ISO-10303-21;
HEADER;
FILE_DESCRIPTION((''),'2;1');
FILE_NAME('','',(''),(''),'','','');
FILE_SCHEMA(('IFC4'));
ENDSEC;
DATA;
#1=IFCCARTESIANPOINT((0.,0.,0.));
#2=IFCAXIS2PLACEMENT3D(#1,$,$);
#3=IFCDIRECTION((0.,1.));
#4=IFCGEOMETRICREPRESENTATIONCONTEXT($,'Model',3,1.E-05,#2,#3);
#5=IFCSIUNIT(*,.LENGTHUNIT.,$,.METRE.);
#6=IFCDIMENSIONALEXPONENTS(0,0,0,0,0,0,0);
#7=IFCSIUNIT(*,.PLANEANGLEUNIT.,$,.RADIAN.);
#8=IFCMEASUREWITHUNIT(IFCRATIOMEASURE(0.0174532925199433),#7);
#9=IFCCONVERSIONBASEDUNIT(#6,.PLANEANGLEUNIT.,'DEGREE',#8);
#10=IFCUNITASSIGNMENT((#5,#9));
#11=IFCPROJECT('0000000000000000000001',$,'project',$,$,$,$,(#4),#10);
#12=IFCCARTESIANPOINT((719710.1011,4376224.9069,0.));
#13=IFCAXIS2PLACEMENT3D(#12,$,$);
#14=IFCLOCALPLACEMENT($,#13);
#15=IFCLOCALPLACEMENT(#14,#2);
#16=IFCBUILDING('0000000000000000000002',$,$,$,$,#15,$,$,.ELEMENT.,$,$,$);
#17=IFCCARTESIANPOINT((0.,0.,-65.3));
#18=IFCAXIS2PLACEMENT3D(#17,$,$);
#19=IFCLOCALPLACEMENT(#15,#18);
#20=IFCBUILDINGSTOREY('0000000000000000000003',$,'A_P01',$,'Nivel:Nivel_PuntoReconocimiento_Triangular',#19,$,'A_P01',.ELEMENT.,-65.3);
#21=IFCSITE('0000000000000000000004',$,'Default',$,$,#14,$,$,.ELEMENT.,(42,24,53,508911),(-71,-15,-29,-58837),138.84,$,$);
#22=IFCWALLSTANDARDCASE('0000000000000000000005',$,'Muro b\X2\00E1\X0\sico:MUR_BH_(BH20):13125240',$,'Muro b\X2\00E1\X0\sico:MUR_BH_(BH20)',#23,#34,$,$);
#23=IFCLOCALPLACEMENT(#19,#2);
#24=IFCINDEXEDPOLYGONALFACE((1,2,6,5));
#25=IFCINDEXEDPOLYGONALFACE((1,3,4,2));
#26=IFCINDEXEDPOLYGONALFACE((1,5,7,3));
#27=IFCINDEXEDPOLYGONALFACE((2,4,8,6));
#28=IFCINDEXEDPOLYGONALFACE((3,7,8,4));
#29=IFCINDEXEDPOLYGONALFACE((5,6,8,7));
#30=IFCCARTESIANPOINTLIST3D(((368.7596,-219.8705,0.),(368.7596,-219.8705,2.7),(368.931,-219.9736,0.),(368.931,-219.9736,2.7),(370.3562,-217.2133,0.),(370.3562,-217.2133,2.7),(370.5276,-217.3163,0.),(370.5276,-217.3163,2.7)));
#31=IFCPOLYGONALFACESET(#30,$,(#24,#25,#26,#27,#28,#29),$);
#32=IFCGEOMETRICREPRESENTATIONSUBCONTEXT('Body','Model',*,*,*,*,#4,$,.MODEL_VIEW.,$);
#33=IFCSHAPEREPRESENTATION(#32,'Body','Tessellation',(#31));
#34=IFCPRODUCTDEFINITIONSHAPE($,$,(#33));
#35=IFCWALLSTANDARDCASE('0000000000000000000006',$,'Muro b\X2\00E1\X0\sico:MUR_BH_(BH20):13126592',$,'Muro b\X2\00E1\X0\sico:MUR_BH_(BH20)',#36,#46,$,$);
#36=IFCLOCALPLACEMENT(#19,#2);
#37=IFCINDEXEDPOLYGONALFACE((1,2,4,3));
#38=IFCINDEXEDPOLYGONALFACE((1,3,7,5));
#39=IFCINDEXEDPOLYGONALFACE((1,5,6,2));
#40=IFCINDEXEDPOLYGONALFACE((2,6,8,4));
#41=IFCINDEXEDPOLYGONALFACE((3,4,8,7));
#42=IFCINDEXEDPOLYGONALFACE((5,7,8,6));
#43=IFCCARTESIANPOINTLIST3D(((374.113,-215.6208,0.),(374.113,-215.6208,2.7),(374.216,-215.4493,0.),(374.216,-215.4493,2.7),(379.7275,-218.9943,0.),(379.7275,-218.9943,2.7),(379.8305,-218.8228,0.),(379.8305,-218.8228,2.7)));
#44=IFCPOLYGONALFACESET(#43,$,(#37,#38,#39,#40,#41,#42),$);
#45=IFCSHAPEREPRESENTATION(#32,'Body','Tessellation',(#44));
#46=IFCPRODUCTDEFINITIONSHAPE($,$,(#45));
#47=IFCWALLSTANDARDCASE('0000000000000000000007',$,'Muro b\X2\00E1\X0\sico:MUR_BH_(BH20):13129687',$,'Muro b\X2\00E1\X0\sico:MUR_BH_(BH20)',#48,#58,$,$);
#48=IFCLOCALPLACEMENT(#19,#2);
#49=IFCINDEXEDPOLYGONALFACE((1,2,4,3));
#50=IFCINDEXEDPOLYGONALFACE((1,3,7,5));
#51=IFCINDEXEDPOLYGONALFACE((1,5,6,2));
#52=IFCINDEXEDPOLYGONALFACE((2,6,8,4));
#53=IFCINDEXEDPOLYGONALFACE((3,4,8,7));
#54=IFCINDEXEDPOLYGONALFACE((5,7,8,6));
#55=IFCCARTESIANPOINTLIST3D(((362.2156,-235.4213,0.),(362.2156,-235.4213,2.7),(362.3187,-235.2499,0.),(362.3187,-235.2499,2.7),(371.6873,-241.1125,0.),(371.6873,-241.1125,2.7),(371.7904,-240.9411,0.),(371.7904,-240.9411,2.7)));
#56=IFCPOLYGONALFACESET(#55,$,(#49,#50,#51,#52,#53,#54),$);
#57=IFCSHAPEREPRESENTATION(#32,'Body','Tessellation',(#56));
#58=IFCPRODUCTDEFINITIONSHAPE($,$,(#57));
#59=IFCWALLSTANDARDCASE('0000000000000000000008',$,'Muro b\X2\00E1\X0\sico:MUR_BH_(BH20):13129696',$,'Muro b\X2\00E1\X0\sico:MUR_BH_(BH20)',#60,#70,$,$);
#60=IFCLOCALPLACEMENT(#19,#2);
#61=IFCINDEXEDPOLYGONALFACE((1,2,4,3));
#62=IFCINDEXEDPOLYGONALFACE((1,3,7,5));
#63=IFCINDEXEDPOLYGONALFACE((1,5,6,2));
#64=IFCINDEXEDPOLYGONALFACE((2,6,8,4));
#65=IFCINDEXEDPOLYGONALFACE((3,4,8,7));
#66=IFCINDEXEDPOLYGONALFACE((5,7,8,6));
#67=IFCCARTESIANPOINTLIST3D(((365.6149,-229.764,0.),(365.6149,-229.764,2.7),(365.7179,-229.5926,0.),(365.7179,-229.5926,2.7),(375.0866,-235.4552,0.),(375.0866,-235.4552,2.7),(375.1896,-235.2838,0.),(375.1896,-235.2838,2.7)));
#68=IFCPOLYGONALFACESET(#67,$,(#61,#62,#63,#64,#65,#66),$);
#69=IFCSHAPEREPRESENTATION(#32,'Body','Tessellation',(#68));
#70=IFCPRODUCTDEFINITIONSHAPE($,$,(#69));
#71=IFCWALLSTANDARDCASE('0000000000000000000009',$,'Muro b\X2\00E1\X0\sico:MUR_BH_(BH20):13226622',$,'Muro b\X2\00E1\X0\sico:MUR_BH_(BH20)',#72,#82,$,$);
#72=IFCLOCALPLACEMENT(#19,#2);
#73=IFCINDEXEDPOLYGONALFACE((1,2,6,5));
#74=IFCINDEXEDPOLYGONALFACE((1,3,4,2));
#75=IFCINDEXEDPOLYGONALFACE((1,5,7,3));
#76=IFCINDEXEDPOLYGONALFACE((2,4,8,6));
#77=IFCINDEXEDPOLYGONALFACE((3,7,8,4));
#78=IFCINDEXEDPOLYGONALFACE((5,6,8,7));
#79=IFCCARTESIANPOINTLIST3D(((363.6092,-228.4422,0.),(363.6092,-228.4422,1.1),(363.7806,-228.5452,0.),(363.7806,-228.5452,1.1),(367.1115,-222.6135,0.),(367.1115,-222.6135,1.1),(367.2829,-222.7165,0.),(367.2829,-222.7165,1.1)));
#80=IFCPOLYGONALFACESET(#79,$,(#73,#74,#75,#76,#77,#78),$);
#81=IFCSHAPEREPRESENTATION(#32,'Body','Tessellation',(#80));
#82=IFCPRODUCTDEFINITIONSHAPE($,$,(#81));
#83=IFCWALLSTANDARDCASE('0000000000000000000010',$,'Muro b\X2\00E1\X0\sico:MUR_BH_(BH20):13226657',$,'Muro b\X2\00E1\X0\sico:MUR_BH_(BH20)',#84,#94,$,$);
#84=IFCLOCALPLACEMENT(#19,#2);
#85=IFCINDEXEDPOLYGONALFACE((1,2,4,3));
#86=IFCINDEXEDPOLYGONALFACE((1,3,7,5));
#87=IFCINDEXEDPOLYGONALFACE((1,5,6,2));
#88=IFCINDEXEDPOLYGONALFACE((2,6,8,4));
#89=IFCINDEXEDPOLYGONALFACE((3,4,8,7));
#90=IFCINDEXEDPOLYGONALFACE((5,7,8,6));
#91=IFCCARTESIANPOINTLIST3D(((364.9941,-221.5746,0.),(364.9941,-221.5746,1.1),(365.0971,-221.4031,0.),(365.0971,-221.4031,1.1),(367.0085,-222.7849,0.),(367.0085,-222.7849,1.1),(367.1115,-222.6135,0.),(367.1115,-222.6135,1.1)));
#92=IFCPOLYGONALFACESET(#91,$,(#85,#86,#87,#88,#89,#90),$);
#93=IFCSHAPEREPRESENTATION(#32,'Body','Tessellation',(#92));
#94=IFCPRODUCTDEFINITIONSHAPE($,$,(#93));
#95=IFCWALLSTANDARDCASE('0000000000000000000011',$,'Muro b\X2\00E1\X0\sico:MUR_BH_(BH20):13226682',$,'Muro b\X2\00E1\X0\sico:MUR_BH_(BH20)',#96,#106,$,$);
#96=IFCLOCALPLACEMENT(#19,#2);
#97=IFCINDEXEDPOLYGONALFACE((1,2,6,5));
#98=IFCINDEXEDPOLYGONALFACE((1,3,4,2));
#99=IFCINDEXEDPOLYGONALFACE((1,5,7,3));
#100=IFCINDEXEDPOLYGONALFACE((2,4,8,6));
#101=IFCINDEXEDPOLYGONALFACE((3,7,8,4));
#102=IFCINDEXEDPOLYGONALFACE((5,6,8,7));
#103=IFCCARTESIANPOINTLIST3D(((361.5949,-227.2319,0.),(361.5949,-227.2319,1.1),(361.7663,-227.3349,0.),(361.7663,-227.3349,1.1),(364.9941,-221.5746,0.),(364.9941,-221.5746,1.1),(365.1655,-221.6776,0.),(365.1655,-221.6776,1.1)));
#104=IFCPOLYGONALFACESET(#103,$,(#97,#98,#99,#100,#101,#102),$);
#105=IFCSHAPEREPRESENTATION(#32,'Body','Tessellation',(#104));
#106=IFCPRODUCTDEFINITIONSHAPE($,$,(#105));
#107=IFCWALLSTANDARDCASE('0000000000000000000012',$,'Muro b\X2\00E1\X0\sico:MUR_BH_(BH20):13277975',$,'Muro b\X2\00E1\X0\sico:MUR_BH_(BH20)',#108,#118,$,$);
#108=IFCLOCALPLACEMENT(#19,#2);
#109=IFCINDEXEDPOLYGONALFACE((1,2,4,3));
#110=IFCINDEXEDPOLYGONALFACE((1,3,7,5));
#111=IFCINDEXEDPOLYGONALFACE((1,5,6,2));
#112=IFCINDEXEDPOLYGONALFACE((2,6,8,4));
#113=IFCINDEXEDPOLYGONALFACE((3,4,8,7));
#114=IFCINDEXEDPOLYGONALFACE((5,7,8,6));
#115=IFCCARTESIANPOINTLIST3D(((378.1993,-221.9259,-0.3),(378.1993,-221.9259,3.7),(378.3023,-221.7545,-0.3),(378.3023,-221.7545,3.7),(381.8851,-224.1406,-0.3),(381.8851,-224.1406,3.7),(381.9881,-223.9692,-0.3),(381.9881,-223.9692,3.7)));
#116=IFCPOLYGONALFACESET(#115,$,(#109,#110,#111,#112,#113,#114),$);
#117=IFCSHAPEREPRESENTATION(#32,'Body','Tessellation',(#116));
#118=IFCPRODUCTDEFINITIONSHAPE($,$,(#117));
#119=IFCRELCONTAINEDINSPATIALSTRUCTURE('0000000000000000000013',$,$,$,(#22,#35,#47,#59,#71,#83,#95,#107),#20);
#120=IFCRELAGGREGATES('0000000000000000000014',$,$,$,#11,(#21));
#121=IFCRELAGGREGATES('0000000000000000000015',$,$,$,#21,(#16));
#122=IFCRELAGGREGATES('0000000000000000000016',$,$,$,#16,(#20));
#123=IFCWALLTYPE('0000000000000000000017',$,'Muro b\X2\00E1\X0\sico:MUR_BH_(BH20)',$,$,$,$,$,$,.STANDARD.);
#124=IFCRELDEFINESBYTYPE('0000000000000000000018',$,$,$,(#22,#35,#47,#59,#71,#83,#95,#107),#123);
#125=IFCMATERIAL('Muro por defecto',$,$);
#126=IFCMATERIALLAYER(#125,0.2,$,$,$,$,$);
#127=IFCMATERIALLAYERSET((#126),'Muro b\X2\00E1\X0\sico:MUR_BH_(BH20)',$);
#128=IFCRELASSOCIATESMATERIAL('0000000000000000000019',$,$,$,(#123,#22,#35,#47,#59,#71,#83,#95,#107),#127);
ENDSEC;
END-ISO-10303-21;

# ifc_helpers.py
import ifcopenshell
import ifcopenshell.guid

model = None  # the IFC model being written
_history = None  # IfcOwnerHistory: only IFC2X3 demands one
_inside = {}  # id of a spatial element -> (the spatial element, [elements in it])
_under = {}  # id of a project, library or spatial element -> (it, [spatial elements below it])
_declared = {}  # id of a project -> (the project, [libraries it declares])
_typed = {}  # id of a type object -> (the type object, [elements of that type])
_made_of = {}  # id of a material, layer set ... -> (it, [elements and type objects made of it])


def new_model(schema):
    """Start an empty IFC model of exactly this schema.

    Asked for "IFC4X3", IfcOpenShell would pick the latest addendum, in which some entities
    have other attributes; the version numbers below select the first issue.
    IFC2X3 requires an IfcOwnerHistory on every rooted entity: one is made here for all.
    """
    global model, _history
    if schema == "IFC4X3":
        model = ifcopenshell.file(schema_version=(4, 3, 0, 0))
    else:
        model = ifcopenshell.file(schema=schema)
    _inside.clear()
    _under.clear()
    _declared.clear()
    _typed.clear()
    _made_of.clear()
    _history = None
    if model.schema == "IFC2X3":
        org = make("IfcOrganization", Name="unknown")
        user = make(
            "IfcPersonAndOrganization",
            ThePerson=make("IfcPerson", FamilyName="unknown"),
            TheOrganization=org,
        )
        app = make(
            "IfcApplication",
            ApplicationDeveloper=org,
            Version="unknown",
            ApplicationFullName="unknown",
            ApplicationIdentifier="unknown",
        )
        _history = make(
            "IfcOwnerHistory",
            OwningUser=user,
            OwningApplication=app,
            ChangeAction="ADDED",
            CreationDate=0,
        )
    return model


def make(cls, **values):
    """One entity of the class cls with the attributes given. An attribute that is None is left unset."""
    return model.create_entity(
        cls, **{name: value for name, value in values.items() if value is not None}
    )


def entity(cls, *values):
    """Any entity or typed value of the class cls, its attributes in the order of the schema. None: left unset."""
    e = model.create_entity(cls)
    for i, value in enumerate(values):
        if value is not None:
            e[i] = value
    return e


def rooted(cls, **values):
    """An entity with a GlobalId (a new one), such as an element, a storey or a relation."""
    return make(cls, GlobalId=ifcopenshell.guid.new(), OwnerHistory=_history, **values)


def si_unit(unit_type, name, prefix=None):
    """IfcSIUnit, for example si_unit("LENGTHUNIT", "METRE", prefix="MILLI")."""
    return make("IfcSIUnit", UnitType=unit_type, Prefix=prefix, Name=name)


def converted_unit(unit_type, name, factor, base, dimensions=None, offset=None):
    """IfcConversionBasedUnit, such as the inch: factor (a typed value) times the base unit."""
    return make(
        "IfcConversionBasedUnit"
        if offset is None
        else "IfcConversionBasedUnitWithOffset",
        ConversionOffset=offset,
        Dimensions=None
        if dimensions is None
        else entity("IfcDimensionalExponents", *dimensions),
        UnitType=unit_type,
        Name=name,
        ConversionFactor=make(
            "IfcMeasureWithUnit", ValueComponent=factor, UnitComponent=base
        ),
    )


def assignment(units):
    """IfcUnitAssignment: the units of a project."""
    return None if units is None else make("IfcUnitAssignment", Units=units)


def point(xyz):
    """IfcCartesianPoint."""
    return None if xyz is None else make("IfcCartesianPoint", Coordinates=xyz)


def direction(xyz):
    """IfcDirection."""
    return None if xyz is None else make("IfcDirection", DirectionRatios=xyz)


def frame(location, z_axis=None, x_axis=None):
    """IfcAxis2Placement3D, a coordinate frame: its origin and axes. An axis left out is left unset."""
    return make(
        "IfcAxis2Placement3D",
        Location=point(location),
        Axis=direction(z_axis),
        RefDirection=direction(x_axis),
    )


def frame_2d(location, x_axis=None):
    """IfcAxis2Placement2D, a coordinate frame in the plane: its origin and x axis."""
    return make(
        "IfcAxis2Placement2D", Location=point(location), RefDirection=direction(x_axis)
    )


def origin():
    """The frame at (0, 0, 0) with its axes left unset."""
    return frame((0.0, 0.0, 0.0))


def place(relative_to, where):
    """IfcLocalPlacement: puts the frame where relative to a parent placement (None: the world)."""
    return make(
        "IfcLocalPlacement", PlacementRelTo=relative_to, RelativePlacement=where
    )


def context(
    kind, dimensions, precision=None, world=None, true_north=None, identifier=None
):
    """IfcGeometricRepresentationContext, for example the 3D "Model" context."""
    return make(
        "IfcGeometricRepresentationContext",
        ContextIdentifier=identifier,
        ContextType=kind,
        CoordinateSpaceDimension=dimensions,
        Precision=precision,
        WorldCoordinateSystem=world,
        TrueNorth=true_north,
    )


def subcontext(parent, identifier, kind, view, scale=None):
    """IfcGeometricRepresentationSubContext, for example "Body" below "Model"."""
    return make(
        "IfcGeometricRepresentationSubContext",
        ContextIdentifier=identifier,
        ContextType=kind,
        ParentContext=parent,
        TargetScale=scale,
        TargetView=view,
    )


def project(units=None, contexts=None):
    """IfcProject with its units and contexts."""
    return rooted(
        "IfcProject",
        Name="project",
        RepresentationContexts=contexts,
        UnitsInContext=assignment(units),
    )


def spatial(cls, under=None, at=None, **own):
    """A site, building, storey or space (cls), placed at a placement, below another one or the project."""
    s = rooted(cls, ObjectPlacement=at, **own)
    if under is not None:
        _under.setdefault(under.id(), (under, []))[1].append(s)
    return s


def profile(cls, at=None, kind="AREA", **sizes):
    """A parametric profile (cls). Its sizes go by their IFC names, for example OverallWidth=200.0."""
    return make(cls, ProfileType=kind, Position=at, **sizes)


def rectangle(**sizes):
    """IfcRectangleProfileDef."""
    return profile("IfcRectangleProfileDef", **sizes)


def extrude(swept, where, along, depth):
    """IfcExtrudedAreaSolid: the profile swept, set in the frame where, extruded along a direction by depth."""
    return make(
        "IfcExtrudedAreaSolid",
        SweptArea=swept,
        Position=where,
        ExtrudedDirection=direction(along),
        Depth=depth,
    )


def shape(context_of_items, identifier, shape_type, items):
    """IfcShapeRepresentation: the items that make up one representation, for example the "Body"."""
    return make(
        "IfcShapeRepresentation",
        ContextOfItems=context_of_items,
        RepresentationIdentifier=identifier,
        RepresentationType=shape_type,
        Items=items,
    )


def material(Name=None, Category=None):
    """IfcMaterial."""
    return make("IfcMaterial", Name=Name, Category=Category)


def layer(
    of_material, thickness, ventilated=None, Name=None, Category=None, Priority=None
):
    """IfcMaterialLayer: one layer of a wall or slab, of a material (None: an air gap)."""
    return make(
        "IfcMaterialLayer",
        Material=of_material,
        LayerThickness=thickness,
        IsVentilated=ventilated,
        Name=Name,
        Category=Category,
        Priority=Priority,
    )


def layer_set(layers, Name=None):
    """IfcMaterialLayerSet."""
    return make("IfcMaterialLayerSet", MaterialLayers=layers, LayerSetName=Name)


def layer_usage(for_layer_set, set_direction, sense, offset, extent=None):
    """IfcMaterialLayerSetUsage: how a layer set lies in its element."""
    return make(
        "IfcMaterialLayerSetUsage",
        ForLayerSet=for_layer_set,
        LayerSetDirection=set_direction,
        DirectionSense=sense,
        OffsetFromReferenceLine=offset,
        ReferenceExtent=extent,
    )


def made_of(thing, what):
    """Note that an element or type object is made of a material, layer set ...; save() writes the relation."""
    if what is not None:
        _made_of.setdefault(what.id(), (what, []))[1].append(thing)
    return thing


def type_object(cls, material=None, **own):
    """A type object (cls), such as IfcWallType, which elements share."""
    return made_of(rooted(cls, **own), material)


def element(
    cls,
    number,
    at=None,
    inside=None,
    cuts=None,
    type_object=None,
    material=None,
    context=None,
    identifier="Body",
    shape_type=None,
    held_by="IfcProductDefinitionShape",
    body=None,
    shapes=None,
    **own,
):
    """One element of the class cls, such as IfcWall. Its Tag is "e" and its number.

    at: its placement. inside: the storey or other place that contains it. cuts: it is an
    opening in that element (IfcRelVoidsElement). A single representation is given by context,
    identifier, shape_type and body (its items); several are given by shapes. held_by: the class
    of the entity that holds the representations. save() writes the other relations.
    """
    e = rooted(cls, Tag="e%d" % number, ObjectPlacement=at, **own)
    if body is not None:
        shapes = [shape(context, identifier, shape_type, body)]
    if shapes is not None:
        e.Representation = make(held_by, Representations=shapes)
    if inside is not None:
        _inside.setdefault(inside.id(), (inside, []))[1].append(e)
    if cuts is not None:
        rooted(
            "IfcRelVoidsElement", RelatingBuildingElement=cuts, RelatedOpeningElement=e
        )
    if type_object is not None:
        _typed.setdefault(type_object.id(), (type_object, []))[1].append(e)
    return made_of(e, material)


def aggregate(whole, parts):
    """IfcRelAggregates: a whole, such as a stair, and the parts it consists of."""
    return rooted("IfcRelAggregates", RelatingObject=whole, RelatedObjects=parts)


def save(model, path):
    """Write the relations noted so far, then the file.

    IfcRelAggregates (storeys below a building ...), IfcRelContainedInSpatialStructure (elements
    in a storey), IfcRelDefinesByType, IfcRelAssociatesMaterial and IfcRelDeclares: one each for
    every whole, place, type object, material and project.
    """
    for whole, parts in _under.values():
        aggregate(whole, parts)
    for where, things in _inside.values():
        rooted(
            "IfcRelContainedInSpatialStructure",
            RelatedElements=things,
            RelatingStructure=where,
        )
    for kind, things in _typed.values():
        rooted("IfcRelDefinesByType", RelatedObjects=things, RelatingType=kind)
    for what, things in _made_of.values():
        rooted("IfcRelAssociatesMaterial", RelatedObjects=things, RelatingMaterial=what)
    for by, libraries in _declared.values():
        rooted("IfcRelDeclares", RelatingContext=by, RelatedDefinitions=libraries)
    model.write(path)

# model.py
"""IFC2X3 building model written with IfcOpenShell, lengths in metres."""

from ifc_helpers import new_model, entity, si_unit, converted_unit, direction, frame, frame_2d, origin, place, context, subcontext, project, spatial, rectangle, extrude, material, layer, layer_set, layer_usage, type_object, element, save


model = new_model("IFC2X3")

# Units and contexts
model_context = context("Model", 3, precision=1e-05, world=origin(), true_north=direction((0.0, 1.0)))
body_context = subcontext(model_context, "Body", "Model", "MODEL_VIEW")
ifc_project = project(units=[si_unit("LENGTHUNIT", "METRE"), converted_unit("PLANEANGLEUNIT", "DEGREE", entity("IfcRatioMeasure", 0.0174532925199433), si_unit("PLANEANGLEUNIT", "RADIAN"), dimensions=[0, 0, 0, 0, 0, 0, 0])], contexts=[model_context])

# Site, building, storey
site_placement = place(None, frame((719710.1011, 4376224.9069, 0.0)))
site = spatial("IfcSite", under=ifc_project, at=site_placement, Name="Default", CompositionType="ELEMENT", RefLatitude=(42, 24, 53, 508911), RefLongitude=(-71, -15, -29, -58837), RefElevation=138.84)
building_placement = place(site_placement, origin())
building = spatial("IfcBuilding", under=site, at=building_placement, CompositionType="ELEMENT")
storey_placement = place(building_placement, frame((0.0, 0.0, -65.3)))
storey = spatial("IfcBuildingStorey", under=building, at=storey_placement, Name="A_P01", ObjectType="Nivel:Nivel_PuntoReconocimiento_Triangular", LongName="A_P01", CompositionType="ELEMENT", Elevation=-65.3)

# Shared definitions
ifc_material_1 = material(Name="Muro por defecto")
ifc_layer = layer(ifc_material_1, 0.2)
ifc_layer_set = layer_set([ifc_layer], Name="Muro básico:MUR_BH_(BH20)")
wall_type = type_object("IfcWallType", Name="Muro básico:MUR_BH_(BH20)", PredefinedType="STANDARD", material=ifc_layer_set)

# Walls
ifc_layer_usage_1 = layer_usage(ifc_layer_set, "AXIS2", "NEGATIVE", 0.1)
wall_1_placement = place(storey_placement, frame((368.8453, -219.9221, 0.0), z_axis=(0.0, 0.0, 1.0), x_axis=(0.515038, 0.857167, 0.0)))
element("IfcWallStandardCase", 1, at=wall_1_placement, inside=storey, type_object=wall_type, material=ifc_layer_usage_1, Name="Muro básico:MUR_BH_(BH20):13125240", ObjectType="Muro básico:MUR_BH_(BH20)", context=body_context, shape_type="SweptSolid", body=[
    extrude(rectangle(XDim=3.1, YDim=0.2, at=frame_2d((1.55, 0.0), x_axis=(-1.0, 0.0))), origin(), (0.0, 0.0, 1.0), 2.7),
])
ifc_layer_usage_2 = layer_usage(ifc_layer_set, "AXIS2", "NEGATIVE", 0.1)
wall_2_placement = place(storey_placement, frame((379.779, -218.9086, 0.0), z_axis=(0.0, 0.0, 1.0), x_axis=(-0.857167, 0.515038, 0.0)))
element("IfcWallStandardCase", 2, at=wall_2_placement, inside=storey, type_object=wall_type, material=ifc_layer_usage_2, Name="Muro básico:MUR_BH_(BH20):13126592", ObjectType="Muro básico:MUR_BH_(BH20)", context=body_context, shape_type="SweptSolid", body=[
    extrude(rectangle(XDim=6.55, YDim=0.2, at=frame_2d((3.275, 0.0), x_axis=(-1.0, 0.0))), origin(), (0.0, 0.0, 1.0), 2.7),
])
ifc_layer_usage_3 = layer_usage(ifc_layer_set, "AXIS2", "NEGATIVE", 0.1)
wall_3_placement = place(storey_placement, frame((362.2671, -235.3356, 0.0), z_axis=(0.0, 0.0, 1.0), x_axis=(0.857167, -0.515038, 0.0)))
element("IfcWallStandardCase", 3, at=wall_3_placement, inside=storey, type_object=wall_type, material=ifc_layer_usage_3, Name="Muro básico:MUR_BH_(BH20):13129687", ObjectType="Muro básico:MUR_BH_(BH20)", context=body_context, shape_type="SweptSolid", body=[
    extrude(rectangle(XDim=11.05, YDim=0.2, at=frame_2d((5.525, 0.0), x_axis=(-1.0, 0.0))), origin(), (0.0, 0.0, 1.0), 2.7),
])
ifc_layer_usage_4 = layer_usage(ifc_layer_set, "AXIS2", "NEGATIVE", 0.1)
wall_4_placement = place(storey_placement, frame((365.6664, -229.6783, 0.0), z_axis=(0.0, 0.0, 1.0), x_axis=(0.857167, -0.515038, 0.0)))
element("IfcWallStandardCase", 4, at=wall_4_placement, inside=storey, type_object=wall_type, material=ifc_layer_usage_4, Name="Muro básico:MUR_BH_(BH20):13129696", ObjectType="Muro básico:MUR_BH_(BH20)", context=body_context, shape_type="SweptSolid", body=[
    extrude(rectangle(XDim=11.05, YDim=0.2, at=frame_2d((5.525, 0.0), x_axis=(-1.0, 0.0))), origin(), (0.0, 0.0, 1.0), 2.7),
])
ifc_layer_usage_5 = layer_usage(ifc_layer_set, "AXIS2", "NEGATIVE", 0.1)
wall_5_placement = place(storey_placement, frame((363.6949, -228.4937, 0.0), z_axis=(0.0, 0.0, 1.0), x_axis=(0.515038, 0.857167, 0.0)))
element("IfcWallStandardCase", 5, at=wall_5_placement, inside=storey, type_object=wall_type, material=ifc_layer_usage_5, Name="Muro básico:MUR_BH_(BH20):13226622", ObjectType="Muro básico:MUR_BH_(BH20)", context=body_context, shape_type="SweptSolid", body=[
    extrude(rectangle(XDim=6.8, YDim=0.2, at=frame_2d((3.4, 0.0), x_axis=(-1.0, 0.0))), origin(), (0.0, 0.0, 1.0), 1.1),
])
ifc_layer_usage_6 = layer_usage(ifc_layer_set, "AXIS2", "NEGATIVE", 0.1)
wall_6_placement = place(storey_placement, frame((367.06, -222.6992, 0.0), z_axis=(0.0, 0.0, 1.0), x_axis=(-0.857167, 0.515038, 0.0)))
element("IfcWallStandardCase", 6, at=wall_6_placement, inside=storey, type_object=wall_type, material=ifc_layer_usage_6, Name="Muro básico:MUR_BH_(BH20):13226657", ObjectType="Muro básico:MUR_BH_(BH20)", context=body_context, shape_type="SweptSolid", body=[
    extrude(rectangle(XDim=2.35, YDim=0.2, at=frame_2d((1.175, 0.0), x_axis=(-1.0, 0.0))), origin(), (0.0, 0.0, 1.0), 1.1),
])
ifc_layer_usage_7 = layer_usage(ifc_layer_set, "AXIS2", "NEGATIVE", 0.1)
wall_7_placement = place(storey_placement, frame((365.0798, -221.6261, 0.0), z_axis=(0.0, 0.0, 1.0), x_axis=(-0.515038, -0.857167, 0.0)))
element("IfcWallStandardCase", 7, at=wall_7_placement, inside=storey, type_object=wall_type, material=ifc_layer_usage_7, Name="Muro básico:MUR_BH_(BH20):13226682", ObjectType="Muro básico:MUR_BH_(BH20)", context=body_context, shape_type="SweptSolid", body=[
    extrude(rectangle(XDim=6.6, YDim=0.2, at=frame_2d((3.3, 0.0), x_axis=(-1.0, 0.0))), origin(), (0.0, 0.0, 1.0), 1.1),
])
ifc_layer_usage_8 = layer_usage(ifc_layer_set, "AXIS2", "NEGATIVE", 0.1)
wall_8_placement = place(storey_placement, frame((378.2508, -221.8402, -0.3), z_axis=(0.0, 0.0, 1.0), x_axis=(0.857167, -0.515038, 0.0)))
element("IfcWallStandardCase", 8, at=wall_8_placement, inside=storey, type_object=wall_type, material=ifc_layer_usage_8, Name="Muro básico:MUR_BH_(BH20):13277975", ObjectType="Muro básico:MUR_BH_(BH20)", context=body_context, shape_type="SweptSolid", body=[
    extrude(rectangle(XDim=4.3, YDim=0.2, at=frame_2d((2.15, 0.0), x_axis=(-1.0, 0.0))), origin(), (0.0, 0.0, 1.0), 4.0),
])

save(model, "model.ifc")
